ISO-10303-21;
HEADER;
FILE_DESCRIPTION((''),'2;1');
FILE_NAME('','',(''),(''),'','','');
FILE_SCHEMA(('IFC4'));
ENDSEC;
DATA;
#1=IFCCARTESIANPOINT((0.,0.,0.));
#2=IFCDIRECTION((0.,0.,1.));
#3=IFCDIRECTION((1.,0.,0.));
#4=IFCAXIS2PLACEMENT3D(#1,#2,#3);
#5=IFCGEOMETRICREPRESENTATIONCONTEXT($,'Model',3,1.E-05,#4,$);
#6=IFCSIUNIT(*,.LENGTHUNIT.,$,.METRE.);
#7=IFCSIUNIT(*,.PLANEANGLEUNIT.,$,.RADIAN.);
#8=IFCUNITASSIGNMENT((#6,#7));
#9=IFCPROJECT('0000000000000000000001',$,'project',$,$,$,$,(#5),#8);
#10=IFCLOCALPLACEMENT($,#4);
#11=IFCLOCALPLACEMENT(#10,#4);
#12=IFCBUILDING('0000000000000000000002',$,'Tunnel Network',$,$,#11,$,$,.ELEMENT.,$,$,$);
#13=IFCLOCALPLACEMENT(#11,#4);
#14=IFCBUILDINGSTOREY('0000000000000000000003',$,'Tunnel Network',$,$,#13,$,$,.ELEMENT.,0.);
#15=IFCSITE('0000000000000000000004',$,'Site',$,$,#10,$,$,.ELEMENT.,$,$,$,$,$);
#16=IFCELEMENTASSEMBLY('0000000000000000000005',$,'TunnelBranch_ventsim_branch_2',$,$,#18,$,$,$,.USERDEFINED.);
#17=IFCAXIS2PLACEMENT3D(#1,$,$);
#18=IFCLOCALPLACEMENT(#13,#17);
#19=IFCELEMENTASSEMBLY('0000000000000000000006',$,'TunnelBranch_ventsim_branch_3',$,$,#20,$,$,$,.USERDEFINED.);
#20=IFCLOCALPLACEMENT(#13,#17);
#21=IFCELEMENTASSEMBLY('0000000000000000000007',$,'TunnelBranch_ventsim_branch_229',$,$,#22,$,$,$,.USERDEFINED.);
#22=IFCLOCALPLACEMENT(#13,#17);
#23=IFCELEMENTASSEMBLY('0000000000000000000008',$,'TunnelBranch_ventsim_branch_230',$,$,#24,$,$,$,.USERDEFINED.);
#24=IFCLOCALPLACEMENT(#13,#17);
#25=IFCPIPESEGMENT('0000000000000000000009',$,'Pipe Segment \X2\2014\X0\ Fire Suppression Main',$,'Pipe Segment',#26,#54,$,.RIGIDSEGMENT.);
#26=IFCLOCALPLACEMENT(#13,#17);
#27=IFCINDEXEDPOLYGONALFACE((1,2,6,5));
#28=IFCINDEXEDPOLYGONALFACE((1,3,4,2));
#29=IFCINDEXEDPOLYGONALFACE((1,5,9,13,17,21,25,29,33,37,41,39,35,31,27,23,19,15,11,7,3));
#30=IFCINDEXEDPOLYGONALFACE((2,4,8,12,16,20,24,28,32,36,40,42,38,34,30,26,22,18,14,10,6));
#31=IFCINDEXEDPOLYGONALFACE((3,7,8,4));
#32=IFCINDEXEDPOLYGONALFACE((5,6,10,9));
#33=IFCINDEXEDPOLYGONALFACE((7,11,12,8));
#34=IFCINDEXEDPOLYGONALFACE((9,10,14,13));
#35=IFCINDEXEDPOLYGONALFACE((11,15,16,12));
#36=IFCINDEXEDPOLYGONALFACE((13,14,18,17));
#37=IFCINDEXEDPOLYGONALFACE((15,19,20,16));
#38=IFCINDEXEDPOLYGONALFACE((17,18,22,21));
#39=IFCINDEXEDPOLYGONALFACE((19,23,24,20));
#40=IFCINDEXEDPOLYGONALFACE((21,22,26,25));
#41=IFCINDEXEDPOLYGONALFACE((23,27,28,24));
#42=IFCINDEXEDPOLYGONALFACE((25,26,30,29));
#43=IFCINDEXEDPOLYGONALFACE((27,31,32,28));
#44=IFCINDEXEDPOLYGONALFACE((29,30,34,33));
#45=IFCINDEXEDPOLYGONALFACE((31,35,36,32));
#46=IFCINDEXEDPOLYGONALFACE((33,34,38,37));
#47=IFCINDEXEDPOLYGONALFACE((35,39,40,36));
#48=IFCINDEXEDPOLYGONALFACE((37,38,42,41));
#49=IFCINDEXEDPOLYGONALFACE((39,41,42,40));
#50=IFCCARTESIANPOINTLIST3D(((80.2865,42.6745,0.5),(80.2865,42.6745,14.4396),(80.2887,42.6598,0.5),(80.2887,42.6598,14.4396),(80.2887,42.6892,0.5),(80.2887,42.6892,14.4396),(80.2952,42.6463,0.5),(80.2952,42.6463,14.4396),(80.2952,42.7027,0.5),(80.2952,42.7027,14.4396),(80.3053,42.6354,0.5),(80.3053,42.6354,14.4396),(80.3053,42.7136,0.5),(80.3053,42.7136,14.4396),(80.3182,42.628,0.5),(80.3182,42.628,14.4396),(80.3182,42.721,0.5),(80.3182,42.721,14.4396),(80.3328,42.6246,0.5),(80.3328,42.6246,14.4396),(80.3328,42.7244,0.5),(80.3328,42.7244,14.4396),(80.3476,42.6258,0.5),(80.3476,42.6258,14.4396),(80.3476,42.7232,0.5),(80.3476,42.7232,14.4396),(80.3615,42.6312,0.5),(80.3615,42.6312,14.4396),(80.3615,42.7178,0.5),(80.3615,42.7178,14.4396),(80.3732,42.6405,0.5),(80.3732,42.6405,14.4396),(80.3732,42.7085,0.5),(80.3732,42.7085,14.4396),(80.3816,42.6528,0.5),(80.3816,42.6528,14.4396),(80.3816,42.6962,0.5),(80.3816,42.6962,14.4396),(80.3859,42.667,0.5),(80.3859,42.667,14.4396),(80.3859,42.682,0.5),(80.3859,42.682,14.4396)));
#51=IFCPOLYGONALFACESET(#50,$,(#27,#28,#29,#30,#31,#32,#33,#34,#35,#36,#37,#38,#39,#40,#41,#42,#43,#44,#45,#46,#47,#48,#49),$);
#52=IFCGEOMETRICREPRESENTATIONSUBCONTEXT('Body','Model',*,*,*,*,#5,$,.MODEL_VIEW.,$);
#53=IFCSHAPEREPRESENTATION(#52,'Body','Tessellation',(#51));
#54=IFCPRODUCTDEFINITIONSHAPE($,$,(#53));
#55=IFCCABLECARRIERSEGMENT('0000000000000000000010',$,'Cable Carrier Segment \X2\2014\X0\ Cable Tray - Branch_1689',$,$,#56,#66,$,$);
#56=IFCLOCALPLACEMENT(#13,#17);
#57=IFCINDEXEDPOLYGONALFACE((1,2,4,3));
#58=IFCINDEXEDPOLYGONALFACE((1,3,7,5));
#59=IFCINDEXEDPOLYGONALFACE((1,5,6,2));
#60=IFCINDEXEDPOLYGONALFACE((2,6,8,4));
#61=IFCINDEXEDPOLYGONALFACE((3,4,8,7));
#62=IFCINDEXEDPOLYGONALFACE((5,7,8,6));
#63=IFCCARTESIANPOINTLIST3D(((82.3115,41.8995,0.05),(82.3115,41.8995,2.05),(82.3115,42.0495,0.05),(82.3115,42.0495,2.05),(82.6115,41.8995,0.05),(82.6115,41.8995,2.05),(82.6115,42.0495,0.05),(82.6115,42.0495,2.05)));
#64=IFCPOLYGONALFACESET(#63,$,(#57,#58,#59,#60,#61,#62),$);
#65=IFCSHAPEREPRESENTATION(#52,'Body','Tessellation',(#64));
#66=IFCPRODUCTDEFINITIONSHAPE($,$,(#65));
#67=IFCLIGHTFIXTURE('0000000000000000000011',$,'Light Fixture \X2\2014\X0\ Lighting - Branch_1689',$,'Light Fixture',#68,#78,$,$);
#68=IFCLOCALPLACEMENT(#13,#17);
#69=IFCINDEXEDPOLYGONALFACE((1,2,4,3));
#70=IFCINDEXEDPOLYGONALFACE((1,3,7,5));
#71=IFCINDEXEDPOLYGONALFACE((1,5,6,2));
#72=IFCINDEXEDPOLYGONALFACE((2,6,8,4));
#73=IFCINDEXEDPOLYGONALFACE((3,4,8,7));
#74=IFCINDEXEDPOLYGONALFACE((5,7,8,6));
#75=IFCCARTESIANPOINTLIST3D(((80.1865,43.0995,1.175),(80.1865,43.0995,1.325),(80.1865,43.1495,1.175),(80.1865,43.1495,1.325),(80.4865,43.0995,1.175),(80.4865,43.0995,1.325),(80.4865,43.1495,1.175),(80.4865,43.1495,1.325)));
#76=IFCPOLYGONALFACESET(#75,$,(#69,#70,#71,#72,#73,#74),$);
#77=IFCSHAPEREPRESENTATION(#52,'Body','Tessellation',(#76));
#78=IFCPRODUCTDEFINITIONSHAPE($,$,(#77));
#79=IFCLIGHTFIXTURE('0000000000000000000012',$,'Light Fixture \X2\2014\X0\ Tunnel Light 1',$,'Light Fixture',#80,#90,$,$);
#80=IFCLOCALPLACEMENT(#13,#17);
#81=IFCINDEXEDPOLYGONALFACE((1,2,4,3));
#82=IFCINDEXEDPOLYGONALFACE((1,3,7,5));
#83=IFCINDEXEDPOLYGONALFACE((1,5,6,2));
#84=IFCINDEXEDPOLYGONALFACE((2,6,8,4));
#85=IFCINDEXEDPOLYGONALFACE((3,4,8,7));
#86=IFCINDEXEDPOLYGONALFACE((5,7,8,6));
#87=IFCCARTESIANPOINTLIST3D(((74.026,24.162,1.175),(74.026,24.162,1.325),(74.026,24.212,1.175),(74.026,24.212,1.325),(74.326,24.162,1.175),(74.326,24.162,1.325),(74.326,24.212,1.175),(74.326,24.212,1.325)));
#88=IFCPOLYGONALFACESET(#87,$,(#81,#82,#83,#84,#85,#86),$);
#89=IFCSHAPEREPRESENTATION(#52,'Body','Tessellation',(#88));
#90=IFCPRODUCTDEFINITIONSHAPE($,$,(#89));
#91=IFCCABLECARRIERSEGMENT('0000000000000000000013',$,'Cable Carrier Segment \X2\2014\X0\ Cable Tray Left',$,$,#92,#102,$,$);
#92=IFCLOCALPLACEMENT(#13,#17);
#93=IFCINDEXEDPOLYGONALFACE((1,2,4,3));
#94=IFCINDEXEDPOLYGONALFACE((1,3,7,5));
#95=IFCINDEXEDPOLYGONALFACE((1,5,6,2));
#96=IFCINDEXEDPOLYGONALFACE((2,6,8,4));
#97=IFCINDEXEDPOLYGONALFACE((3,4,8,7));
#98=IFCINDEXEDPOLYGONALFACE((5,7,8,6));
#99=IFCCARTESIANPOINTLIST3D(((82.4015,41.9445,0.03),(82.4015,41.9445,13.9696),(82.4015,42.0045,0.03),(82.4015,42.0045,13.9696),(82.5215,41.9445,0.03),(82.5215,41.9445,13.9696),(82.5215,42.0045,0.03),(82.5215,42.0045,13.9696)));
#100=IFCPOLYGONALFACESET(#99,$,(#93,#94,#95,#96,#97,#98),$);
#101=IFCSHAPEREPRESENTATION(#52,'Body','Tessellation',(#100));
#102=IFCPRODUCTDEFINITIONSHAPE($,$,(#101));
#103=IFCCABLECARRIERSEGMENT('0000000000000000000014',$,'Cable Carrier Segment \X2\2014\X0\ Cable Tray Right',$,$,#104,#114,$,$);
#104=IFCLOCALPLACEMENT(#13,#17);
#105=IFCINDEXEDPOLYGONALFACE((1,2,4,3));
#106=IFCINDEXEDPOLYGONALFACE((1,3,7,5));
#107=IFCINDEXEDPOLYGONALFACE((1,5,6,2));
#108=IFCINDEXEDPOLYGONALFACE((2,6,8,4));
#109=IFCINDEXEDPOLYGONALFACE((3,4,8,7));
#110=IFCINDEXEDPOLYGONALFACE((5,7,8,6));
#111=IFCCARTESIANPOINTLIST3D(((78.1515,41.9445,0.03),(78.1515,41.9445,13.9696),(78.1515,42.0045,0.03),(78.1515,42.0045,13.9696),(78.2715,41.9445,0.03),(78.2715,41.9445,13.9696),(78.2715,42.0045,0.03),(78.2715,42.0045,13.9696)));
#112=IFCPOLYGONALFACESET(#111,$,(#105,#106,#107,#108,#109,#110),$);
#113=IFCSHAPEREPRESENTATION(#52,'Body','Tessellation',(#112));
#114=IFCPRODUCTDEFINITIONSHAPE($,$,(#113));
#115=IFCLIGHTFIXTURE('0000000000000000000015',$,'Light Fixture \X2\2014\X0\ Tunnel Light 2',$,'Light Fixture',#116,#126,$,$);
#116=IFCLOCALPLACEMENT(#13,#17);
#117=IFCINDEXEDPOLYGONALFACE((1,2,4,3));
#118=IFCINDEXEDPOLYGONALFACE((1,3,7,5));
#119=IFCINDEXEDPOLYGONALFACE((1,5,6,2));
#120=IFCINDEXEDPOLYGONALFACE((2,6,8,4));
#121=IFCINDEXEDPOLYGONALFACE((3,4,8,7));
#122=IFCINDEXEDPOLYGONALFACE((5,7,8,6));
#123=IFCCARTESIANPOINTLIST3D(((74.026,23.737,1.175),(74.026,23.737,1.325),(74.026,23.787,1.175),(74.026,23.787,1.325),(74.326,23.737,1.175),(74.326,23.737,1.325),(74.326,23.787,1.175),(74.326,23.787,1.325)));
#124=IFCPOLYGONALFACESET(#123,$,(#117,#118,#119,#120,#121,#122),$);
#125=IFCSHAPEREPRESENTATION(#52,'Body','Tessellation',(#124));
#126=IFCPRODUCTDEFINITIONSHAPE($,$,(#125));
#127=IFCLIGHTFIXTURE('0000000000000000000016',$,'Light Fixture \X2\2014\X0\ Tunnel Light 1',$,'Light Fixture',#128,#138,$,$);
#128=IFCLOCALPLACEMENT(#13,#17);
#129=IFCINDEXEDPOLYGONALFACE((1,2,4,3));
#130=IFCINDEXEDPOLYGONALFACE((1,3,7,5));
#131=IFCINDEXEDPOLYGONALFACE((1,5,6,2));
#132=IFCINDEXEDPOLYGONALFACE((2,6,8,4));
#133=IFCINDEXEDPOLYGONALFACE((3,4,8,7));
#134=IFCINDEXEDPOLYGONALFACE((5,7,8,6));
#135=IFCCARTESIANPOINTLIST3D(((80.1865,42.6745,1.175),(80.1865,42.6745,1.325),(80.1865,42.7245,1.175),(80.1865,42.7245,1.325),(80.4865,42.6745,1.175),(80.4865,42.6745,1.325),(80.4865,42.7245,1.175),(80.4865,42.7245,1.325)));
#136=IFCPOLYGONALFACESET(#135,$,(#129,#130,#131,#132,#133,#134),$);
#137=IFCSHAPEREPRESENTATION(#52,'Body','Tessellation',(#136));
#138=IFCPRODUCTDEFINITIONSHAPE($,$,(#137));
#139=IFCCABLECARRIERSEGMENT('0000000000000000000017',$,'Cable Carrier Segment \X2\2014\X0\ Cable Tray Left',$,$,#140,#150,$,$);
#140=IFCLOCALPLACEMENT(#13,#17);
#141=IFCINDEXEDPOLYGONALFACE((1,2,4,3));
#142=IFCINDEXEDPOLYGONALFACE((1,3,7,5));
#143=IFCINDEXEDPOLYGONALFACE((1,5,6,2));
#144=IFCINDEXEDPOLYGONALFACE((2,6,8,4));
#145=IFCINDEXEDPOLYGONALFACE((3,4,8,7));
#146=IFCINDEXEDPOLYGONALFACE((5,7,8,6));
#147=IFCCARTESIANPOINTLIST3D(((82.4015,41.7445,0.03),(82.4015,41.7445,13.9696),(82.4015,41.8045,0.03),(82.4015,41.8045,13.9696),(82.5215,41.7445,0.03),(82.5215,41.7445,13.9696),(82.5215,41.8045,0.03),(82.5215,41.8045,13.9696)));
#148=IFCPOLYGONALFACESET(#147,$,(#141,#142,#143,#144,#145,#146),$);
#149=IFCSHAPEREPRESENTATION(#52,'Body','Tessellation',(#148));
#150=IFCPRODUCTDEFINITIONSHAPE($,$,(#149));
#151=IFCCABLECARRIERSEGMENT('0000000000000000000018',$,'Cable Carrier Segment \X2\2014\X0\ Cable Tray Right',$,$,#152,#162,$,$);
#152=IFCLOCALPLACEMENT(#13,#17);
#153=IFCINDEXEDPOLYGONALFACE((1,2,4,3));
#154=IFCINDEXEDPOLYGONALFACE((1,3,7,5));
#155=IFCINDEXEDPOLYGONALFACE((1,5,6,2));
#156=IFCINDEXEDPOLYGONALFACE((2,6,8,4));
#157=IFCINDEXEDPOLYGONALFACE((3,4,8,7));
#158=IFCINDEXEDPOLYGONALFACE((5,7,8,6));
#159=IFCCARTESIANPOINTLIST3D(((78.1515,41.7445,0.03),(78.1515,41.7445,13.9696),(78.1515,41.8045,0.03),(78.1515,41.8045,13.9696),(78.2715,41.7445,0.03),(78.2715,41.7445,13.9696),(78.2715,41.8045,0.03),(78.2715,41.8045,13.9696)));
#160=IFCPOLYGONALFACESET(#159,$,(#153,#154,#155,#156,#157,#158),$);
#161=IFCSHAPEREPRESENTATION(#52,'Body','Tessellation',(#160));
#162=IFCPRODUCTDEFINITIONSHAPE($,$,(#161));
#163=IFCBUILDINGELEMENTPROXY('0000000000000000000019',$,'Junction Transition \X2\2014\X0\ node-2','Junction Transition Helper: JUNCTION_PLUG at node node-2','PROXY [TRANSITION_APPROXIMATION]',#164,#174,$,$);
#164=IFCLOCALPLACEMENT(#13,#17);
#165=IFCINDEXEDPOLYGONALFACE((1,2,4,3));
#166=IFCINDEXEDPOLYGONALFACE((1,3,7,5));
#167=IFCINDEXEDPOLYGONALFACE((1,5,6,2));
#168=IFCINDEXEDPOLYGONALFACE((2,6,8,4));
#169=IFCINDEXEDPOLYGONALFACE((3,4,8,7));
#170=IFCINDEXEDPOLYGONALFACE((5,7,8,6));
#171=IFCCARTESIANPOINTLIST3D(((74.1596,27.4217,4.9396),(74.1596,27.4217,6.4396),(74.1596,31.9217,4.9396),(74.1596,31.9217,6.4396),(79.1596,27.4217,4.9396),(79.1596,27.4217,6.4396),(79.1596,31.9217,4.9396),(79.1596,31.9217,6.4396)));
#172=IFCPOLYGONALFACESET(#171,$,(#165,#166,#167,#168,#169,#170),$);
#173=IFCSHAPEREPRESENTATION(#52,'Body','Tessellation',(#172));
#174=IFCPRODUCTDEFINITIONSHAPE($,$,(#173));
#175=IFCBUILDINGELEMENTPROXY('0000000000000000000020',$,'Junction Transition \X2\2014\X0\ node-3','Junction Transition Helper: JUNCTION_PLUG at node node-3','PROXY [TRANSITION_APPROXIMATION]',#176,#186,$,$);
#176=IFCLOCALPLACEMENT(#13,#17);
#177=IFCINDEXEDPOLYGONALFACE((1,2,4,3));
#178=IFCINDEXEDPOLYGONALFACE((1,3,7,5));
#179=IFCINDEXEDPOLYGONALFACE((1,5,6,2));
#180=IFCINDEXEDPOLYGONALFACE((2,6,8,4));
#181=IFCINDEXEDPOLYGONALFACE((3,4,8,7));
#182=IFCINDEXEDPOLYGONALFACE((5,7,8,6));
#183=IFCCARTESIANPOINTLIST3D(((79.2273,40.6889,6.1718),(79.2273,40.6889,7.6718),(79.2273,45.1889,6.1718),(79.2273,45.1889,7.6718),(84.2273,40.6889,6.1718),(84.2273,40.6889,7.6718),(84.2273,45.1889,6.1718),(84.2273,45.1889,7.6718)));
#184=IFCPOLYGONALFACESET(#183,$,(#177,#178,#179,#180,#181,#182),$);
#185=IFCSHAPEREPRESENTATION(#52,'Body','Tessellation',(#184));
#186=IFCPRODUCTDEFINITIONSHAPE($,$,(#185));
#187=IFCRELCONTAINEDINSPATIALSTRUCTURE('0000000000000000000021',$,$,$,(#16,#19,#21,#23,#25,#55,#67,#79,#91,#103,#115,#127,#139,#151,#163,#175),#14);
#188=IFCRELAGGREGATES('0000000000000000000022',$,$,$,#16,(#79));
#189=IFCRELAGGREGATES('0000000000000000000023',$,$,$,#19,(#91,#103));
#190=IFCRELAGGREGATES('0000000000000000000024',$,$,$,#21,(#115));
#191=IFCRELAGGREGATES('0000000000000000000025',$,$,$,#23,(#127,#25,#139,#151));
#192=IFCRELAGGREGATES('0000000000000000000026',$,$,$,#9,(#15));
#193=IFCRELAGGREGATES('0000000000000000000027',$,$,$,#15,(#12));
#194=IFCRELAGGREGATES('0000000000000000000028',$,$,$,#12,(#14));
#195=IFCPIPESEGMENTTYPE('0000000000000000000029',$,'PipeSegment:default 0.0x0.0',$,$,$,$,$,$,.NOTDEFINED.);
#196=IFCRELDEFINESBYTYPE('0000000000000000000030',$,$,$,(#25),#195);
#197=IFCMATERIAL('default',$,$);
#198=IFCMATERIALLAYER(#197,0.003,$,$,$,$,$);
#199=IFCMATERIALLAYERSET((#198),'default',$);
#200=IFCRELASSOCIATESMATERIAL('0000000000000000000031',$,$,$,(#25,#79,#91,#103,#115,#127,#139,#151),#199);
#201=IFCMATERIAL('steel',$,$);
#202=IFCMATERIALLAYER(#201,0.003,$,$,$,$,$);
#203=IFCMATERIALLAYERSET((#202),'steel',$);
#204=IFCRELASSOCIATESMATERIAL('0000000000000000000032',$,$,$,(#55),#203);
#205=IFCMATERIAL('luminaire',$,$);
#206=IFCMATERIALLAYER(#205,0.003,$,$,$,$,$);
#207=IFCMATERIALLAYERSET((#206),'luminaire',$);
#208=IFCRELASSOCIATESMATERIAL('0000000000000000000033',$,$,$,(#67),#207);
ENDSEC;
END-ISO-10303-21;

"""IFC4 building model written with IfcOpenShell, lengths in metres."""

from ifc_helpers import new_model, si_unit, frame, origin_with_axes, origin_2d_with_axis, place, context, subcontext, project, spatial, rectangle, circle, extrude, material, layer, layer_set, layer_usage, type_object, element, aggregate, save


model = new_model("IFC4")

# Units and contexts
model_context = context("Model", 3, precision=1e-05, world=origin_with_axes())
body_context = subcontext(model_context, "Body", "Model", "MODEL_VIEW")
ifc_project = project(units=[si_unit("LENGTHUNIT", "METRE"), si_unit("PLANEANGLEUNIT", "RADIAN")], contexts=[model_context])

# Site, building, storey
site_placement = place(None, origin_with_axes())
site = spatial("IfcSite", under=ifc_project, at=site_placement, Name="Site", CompositionType="ELEMENT")
building_placement = place(site_placement, origin_with_axes())
building = spatial("IfcBuilding", under=site, at=building_placement, Name="Tunnel Network", CompositionType="ELEMENT")
storey_placement = place(building_placement, origin_with_axes())
storey = spatial("IfcBuildingStorey", under=building, at=storey_placement, Name="Tunnel Network", CompositionType="ELEMENT", Elevation=0.0)

# Element assemblies, pipe segment
assembly_1_placement = place(storey_placement, frame((74.176, 24.162, 1.25), z_axis=(0.0, 1.0, 0.0), x_axis=(-1.0, 0.0, 0.0)))
assembly_1 = element("IfcElementAssembly", 1, at=assembly_1_placement, inside=storey, Name="TunnelBranch_ventsim_branch_2", PredefinedType="USERDEFINED")
ifc_material_1 = material(Name="default")
ifc_layer_1 = layer(ifc_material_1, 0.003)
ifc_layer_set_1 = layer_set([ifc_layer_1], Name="default")
pipe_segment_type = type_object("IfcPipeSegmentType", Name="PipeSegment:default 0.0x0.0")
assembly_2_placement = place(storey_placement, frame((80.3365, 43.0995, 0.5), z_axis=(0.0, 0.0, 1.0), x_axis=(-1.0, 0.0, 0.0)))
assembly_2 = element("IfcElementAssembly", 2, at=assembly_2_placement, inside=storey, Name="TunnelBranch_ventsim_branch_3", PredefinedType="USERDEFINED")
assembly_3_placement = place(storey_placement, frame((74.176, 23.737, 1.25), z_axis=(0.0, 1.0, 0.0), x_axis=(-1.0, 0.0, 0.0)))
assembly_3 = element("IfcElementAssembly", 3, at=assembly_3_placement, inside=storey, Name="TunnelBranch_ventsim_branch_229", PredefinedType="USERDEFINED")
assembly_4_placement = place(storey_placement, frame((80.3365, 42.6745, 1.25), z_axis=(0.0, 1.0, 0.0), x_axis=(-1.0, 0.0, 0.0)))
assembly_4 = element("IfcElementAssembly", 4, at=assembly_4_placement, inside=storey, Name="TunnelBranch_ventsim_branch_230", PredefinedType="USERDEFINED")
ifc_layer_usage_1 = layer_usage(ifc_layer_set_1, "AXIS2", "POSITIVE", 0.0)
pipe_segment_1_placement = place(storey_placement, frame((80.3365, 42.6745, 0.5), z_axis=(0.0, 0.0, 1.0), x_axis=(-1.0, 0.0, 0.0)))
pipe_segment_1 = element("IfcPipeSegment", 5, at=pipe_segment_1_placement, inside=storey, type_object=pipe_segment_type, material=ifc_layer_usage_1, Name="Pipe Segment — Fire Suppression Main", ObjectType="Pipe Segment", PredefinedType="RIGIDSEGMENT", context=body_context, shape_type="SweptSolid", body=[
    extrude(circle(Radius=0.05, at=origin_2d_with_axis()), origin_with_axes(), (0.0, 0.0, 1.0), 13.9396),
])

# Cable carrier segment
ifc_material_2 = material(Name="steel")
ifc_layer_2 = layer(ifc_material_2, 0.003)
ifc_layer_set_2 = layer_set([ifc_layer_2], Name="steel")
ifc_layer_usage_2 = layer_usage(ifc_layer_set_2, "AXIS2", "POSITIVE", 0.0)
cable_carrier_segment_1_placement = place(storey_placement, frame((82.4615, 41.9745, 0.05), z_axis=(0.0, 0.0, 1.0), x_axis=(-1.0, 0.0, 0.0)))
element("IfcCableCarrierSegment", 6, at=cable_carrier_segment_1_placement, inside=storey, material=ifc_layer_usage_2, Name="Cable Carrier Segment — Cable Tray - Branch_1689", context=body_context, shape_type="SweptSolid", body=[
    extrude(rectangle(XDim=0.3, YDim=0.15, at=origin_2d_with_axis()), origin_with_axes(), (0.0, 0.0, 1.0), 2.0),
])

# Light fixture
ifc_material_3 = material(Name="luminaire")
ifc_layer_3 = layer(ifc_material_3, 0.003)
ifc_layer_set_3 = layer_set([ifc_layer_3], Name="luminaire")
ifc_layer_usage_3 = layer_usage(ifc_layer_set_3, "AXIS2", "POSITIVE", 0.0)
light_fixture_1_placement = place(storey_placement, frame((80.3365, 43.0995, 1.25), z_axis=(0.0, 1.0, 0.0), x_axis=(-1.0, 0.0, 0.0)))
element("IfcLightFixture", 7, at=light_fixture_1_placement, inside=storey, material=ifc_layer_usage_3, Name="Light Fixture — Lighting - Branch_1689", ObjectType="Light Fixture", context=body_context, shape_type="SweptSolid", body=[
    extrude(rectangle(XDim=0.3, YDim=0.15, at=origin_2d_with_axis()), origin_with_axes(), (0.0, 0.0, 1.0), 0.05),
])

# Light fixture
ifc_layer_usage_4 = layer_usage(ifc_layer_set_1, "AXIS2", "POSITIVE", 0.0)
light_fixture_2_placement = place(storey_placement, frame((74.176, 24.162, 1.25), z_axis=(0.0, 1.0, 0.0), x_axis=(-1.0, 0.0, 0.0)))
light_fixture_2 = element("IfcLightFixture", 8, at=light_fixture_2_placement, inside=storey, material=ifc_layer_usage_4, Name="Light Fixture — Tunnel Light 1", ObjectType="Light Fixture", context=body_context, shape_type="SweptSolid", body=[
    extrude(rectangle(XDim=0.3, YDim=0.15, at=origin_2d_with_axis()), origin_with_axes(), (0.0, 0.0, 1.0), 0.05),
])
aggregate(assembly_1, [light_fixture_2])

# Cable carrier segments
ifc_layer_usage_5 = layer_usage(ifc_layer_set_1, "AXIS2", "POSITIVE", 0.0)
cable_carrier_segment_2_placement = place(storey_placement, frame((82.4615, 41.9745, 0.03), z_axis=(0.0, 0.0, 1.0), x_axis=(-1.0, 0.0, 0.0)))
cable_carrier_segment_2 = element("IfcCableCarrierSegment", 9, at=cable_carrier_segment_2_placement, inside=storey, material=ifc_layer_usage_5, Name="Cable Carrier Segment — Cable Tray Left", context=body_context, shape_type="SweptSolid", body=[
    extrude(rectangle(XDim=0.12, YDim=0.06, at=origin_2d_with_axis()), origin_with_axes(), (0.0, 0.0, 1.0), 13.9396),
])
ifc_layer_usage_6 = layer_usage(ifc_layer_set_1, "AXIS2", "POSITIVE", 0.0)
cable_carrier_segment_3_placement = place(storey_placement, frame((78.2115, 41.9745, 0.03), z_axis=(0.0, 0.0, 1.0), x_axis=(-1.0, 0.0, 0.0)))
cable_carrier_segment_3 = element("IfcCableCarrierSegment", 10, at=cable_carrier_segment_3_placement, inside=storey, material=ifc_layer_usage_6, Name="Cable Carrier Segment — Cable Tray Right", context=body_context, shape_type="SweptSolid", body=[
    extrude(rectangle(XDim=0.12, YDim=0.06, at=origin_2d_with_axis()), origin_with_axes(), (0.0, 0.0, 1.0), 13.9396),
])
aggregate(assembly_2, [cable_carrier_segment_2, cable_carrier_segment_3])

# Light fixtures
ifc_layer_usage_7 = layer_usage(ifc_layer_set_1, "AXIS2", "POSITIVE", 0.0)
light_fixture_3_placement = place(storey_placement, frame((74.176, 23.737, 1.25), z_axis=(0.0, 1.0, 0.0), x_axis=(-1.0, 0.0, 0.0)))
light_fixture_3 = element("IfcLightFixture", 11, at=light_fixture_3_placement, inside=storey, material=ifc_layer_usage_7, Name="Light Fixture — Tunnel Light 2", ObjectType="Light Fixture", context=body_context, shape_type="SweptSolid", body=[
    extrude(rectangle(XDim=0.3, YDim=0.15, at=origin_2d_with_axis()), origin_with_axes(), (0.0, 0.0, 1.0), 0.05),
])
aggregate(assembly_3, [light_fixture_3])
ifc_layer_usage_8 = layer_usage(ifc_layer_set_1, "AXIS2", "POSITIVE", 0.0)
light_fixture_4_placement = place(storey_placement, frame((80.3365, 42.6745, 1.25), z_axis=(0.0, 1.0, 0.0), x_axis=(-1.0, 0.0, 0.0)))
light_fixture_4 = element("IfcLightFixture", 12, at=light_fixture_4_placement, inside=storey, material=ifc_layer_usage_8, Name="Light Fixture — Tunnel Light 1", ObjectType="Light Fixture", context=body_context, shape_type="SweptSolid", body=[
    extrude(rectangle(XDim=0.3, YDim=0.15, at=origin_2d_with_axis()), origin_with_axes(), (0.0, 0.0, 1.0), 0.05),
])

# Cable carrier segments
ifc_layer_usage_9 = layer_usage(ifc_layer_set_1, "AXIS2", "POSITIVE", 0.0)
cable_carrier_segment_4_placement = place(storey_placement, frame((82.4615, 41.7745, 0.03), z_axis=(0.0, 0.0, 1.0), x_axis=(-1.0, 0.0, 0.0)))
cable_carrier_segment_4 = element("IfcCableCarrierSegment", 13, at=cable_carrier_segment_4_placement, inside=storey, material=ifc_layer_usage_9, Name="Cable Carrier Segment — Cable Tray Left", context=body_context, shape_type="SweptSolid", body=[
    extrude(rectangle(XDim=0.12, YDim=0.06, at=origin_2d_with_axis()), origin_with_axes(), (0.0, 0.0, 1.0), 13.9396),
])
ifc_layer_usage_10 = layer_usage(ifc_layer_set_1, "AXIS2", "POSITIVE", 0.0)
cable_carrier_segment_5_placement = place(storey_placement, frame((78.2115, 41.7745, 0.03), z_axis=(0.0, 0.0, 1.0), x_axis=(-1.0, 0.0, 0.0)))
cable_carrier_segment_5 = element("IfcCableCarrierSegment", 14, at=cable_carrier_segment_5_placement, inside=storey, material=ifc_layer_usage_10, Name="Cable Carrier Segment — Cable Tray Right", context=body_context, shape_type="SweptSolid", body=[
    extrude(rectangle(XDim=0.12, YDim=0.06, at=origin_2d_with_axis()), origin_with_axes(), (0.0, 0.0, 1.0), 13.9396),
])
aggregate(assembly_4, [light_fixture_4, pipe_segment_1, cable_carrier_segment_4, cable_carrier_segment_5])

# Building element proxies
for number, where, z_axis, x_axis, name, description in (
    (15, (76.6596, 29.6717, 4.9396), (0.0, 0.0, 1.0), (1.0, 0.0, 0.0), "Junction Transition — node-2", "Junction Transition Helper: JUNCTION_PLUG at node node-2"),
    (16, (81.7273, 42.9389, 6.1718), (0.0, 0.0, 1.0), (1.0, 0.0, 0.0), "Junction Transition — node-3", "Junction Transition Helper: JUNCTION_PLUG at node node-3"),
):
    element("IfcBuildingElementProxy", number, at=place(storey_placement, frame(where, z_axis=z_axis, x_axis=x_axis)), inside=storey, Name=name, Description=description, ObjectType="PROXY [TRANSITION_APPROXIMATION]", context=body_context, shape_type="SweptSolid", body=[
        extrude(rectangle(XDim=5.0, YDim=4.5, at=origin_2d_with_axis()), origin_with_axes(), (0.0, 0.0, 1.0), 1.5),
    ])

save(model, "model.ifc")
